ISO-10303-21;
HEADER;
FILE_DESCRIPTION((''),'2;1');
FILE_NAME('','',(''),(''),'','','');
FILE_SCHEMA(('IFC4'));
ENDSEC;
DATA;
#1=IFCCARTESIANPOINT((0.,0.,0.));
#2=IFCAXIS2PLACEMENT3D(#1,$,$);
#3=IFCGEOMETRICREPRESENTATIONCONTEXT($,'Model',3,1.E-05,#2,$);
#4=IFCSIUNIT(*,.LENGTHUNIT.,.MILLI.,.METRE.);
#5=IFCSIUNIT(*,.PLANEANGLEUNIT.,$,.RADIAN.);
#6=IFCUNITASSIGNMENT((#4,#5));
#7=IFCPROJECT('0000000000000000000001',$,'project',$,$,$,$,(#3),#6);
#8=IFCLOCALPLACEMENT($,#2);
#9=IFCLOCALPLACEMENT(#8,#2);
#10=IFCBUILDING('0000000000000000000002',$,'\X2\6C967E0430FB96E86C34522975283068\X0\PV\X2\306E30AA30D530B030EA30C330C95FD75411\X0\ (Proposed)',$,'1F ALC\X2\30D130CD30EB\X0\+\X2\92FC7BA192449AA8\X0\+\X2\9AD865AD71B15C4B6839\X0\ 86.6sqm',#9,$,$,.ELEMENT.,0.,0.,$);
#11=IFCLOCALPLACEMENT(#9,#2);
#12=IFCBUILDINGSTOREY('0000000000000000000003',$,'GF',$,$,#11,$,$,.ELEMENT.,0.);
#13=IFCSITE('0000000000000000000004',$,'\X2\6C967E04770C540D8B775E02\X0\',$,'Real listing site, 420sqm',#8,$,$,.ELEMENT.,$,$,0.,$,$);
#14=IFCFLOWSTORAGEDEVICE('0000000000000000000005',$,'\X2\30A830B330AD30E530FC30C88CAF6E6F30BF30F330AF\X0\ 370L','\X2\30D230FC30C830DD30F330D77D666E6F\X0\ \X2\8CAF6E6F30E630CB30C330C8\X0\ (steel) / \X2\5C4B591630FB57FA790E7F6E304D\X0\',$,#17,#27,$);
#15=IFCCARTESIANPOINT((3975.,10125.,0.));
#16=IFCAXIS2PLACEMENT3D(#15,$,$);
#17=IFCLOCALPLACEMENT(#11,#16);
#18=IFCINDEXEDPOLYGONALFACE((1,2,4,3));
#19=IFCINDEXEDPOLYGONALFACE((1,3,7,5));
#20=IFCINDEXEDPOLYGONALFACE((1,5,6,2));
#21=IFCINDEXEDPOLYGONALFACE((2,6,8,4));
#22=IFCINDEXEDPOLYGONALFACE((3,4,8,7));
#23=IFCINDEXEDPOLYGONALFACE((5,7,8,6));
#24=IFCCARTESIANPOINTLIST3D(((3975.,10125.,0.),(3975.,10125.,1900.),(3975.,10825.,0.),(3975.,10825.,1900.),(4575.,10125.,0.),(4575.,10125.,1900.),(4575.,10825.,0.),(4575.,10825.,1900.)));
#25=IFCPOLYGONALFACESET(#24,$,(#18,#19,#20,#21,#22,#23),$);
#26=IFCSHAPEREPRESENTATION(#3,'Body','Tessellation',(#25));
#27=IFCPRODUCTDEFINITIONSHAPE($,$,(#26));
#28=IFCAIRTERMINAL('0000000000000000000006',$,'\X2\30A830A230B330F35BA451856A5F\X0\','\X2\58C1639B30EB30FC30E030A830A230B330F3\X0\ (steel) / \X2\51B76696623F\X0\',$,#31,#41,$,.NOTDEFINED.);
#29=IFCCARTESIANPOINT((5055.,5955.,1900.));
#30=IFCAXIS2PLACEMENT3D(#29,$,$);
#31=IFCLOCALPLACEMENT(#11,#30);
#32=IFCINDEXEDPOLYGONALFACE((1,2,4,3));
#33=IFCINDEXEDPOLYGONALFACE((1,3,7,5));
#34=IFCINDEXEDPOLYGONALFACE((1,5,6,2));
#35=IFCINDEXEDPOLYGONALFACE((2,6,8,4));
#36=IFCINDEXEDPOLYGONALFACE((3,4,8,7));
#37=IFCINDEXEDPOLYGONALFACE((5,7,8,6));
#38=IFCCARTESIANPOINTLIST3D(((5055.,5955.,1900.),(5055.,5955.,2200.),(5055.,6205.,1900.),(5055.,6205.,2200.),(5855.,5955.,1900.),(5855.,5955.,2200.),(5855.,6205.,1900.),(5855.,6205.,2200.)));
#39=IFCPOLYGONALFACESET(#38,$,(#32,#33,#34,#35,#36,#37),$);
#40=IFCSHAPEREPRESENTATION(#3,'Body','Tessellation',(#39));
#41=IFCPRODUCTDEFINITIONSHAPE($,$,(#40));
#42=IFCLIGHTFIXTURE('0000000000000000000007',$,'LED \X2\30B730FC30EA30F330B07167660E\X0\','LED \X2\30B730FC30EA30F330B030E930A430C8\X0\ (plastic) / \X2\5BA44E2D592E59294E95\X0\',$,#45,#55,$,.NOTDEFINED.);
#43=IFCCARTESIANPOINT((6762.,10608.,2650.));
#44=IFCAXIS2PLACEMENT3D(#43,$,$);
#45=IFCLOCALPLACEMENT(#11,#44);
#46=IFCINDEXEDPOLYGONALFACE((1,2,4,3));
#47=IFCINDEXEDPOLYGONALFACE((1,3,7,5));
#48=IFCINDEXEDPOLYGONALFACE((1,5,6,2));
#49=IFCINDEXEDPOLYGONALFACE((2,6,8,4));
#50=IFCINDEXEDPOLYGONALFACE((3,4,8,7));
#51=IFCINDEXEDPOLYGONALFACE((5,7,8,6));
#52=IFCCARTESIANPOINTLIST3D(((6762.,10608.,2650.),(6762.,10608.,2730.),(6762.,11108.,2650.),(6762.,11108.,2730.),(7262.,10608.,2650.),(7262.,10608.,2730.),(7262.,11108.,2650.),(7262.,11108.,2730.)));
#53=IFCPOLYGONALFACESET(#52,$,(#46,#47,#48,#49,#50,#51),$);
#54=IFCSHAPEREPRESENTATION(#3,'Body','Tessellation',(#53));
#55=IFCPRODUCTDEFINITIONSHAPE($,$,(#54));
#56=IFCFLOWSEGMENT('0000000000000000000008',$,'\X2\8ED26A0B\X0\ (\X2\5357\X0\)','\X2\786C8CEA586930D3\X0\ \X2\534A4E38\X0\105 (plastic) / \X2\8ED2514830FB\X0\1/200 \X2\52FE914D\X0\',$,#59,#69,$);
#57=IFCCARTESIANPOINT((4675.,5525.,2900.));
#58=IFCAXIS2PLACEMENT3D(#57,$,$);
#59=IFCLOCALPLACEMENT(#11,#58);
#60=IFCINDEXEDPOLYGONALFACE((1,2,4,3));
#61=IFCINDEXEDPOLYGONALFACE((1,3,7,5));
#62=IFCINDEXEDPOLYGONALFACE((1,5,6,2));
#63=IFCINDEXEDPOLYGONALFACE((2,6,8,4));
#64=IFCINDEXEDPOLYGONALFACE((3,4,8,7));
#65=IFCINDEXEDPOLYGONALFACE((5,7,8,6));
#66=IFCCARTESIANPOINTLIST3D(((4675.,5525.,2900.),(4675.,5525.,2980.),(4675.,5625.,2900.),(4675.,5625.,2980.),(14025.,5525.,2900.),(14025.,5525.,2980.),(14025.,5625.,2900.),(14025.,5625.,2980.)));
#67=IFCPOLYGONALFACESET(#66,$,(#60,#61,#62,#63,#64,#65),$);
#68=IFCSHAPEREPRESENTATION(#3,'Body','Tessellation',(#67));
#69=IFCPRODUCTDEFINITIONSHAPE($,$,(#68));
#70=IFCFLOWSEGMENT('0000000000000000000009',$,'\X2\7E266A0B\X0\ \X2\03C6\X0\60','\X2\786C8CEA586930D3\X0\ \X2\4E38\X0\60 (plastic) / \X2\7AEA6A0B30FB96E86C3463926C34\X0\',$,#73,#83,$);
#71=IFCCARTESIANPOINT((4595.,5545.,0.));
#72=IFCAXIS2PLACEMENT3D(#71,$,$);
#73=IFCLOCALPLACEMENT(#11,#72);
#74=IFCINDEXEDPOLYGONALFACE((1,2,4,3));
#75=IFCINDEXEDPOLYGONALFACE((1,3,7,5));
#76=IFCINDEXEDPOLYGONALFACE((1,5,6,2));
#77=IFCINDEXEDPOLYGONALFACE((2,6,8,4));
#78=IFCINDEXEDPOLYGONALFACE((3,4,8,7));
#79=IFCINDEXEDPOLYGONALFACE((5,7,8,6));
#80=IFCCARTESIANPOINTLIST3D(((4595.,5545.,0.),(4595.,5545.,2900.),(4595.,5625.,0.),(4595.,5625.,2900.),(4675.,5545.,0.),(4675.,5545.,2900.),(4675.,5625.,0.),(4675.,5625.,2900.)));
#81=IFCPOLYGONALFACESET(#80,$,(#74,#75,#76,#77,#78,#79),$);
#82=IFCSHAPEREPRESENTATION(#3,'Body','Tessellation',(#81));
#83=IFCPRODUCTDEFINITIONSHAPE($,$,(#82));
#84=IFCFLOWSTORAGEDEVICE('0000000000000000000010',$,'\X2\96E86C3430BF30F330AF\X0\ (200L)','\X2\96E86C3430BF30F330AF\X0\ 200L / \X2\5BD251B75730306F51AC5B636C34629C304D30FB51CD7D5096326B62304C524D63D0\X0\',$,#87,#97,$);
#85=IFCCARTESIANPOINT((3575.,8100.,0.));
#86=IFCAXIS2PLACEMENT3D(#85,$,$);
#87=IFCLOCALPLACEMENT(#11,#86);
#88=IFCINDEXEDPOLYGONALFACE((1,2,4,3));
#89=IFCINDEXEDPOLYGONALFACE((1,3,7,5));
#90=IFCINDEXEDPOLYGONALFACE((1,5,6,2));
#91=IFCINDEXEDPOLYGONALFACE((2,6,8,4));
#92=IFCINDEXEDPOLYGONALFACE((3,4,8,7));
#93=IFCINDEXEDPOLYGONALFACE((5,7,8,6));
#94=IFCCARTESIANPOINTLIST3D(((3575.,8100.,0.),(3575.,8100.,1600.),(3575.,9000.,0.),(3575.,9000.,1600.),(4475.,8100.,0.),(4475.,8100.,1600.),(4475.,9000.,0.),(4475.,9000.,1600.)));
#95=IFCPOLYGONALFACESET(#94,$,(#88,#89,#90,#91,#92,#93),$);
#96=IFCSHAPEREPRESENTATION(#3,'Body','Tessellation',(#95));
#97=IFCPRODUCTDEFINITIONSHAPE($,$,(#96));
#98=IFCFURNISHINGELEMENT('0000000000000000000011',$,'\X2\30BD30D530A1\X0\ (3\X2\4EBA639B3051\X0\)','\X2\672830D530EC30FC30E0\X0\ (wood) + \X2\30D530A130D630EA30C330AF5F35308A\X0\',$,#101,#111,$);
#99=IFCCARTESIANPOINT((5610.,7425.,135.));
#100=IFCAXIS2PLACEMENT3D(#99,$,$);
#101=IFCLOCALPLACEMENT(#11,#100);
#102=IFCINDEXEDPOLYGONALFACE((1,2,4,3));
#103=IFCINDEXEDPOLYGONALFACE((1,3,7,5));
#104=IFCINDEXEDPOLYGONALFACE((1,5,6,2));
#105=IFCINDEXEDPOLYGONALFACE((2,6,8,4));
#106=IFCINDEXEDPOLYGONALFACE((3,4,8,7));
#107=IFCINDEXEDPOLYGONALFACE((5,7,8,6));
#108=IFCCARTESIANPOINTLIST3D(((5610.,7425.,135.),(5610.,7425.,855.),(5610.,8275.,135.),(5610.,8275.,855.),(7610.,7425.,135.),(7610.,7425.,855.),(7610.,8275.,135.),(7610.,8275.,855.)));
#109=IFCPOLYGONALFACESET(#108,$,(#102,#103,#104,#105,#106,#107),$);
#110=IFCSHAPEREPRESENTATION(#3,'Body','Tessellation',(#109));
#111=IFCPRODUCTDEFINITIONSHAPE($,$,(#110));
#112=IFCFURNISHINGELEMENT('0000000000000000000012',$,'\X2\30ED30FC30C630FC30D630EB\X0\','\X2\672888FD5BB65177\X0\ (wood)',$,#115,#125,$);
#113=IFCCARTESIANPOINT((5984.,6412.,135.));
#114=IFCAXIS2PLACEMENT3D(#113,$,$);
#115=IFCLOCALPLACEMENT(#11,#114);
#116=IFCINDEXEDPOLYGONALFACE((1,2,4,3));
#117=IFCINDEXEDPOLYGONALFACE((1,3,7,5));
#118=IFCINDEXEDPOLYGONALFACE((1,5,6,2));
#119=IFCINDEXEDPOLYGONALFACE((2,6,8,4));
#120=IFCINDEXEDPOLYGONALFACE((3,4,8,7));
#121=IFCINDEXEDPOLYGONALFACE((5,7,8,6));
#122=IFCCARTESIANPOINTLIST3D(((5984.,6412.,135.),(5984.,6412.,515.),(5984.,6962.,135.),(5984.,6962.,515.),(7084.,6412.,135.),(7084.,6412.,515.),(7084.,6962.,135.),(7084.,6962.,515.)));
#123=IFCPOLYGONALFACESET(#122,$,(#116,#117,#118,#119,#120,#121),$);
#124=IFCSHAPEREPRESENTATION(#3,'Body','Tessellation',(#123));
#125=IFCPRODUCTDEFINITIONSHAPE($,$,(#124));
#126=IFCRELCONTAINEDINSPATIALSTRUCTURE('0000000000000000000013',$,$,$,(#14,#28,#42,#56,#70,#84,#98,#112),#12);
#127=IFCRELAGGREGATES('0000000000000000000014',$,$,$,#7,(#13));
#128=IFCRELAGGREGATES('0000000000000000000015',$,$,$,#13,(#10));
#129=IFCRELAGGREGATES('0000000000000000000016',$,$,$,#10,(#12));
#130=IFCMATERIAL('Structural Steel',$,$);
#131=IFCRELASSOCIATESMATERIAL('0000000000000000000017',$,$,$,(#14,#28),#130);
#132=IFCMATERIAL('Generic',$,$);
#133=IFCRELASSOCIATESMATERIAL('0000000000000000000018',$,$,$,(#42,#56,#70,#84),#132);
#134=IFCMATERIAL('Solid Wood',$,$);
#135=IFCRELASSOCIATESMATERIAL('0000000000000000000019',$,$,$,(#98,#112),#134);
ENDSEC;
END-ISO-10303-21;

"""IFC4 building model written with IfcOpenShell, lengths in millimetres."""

from ifc_helpers import new_model, si_unit, frame, frame_2d, origin, place, context, project, spatial, rectangle, extrude, material, element, save


model = new_model("IFC4")

# Units and contexts
model_context = context("Model", 3, precision=1e-05, world=origin())
ifc_project = project(units=[si_unit("LENGTHUNIT", "METRE", prefix="MILLI"), si_unit("PLANEANGLEUNIT", "RADIAN")], contexts=[model_context])

# Site, building, storey
site_placement = place(None, origin())
site = spatial("IfcSite", under=ifc_project, at=site_placement, Name="沖縄県名護市", ObjectType="Real listing site, 420sqm", CompositionType="ELEMENT", RefElevation=0.0)
building_placement = place(site_placement, origin())
building = spatial("IfcBuilding", under=site, at=building_placement, Name="沖縄・雨水利用とPVのオフグリッド志向 (Proposed)", ObjectType="1F ALCパネル+鋼管鉄骨+高断熱屋根 86.6sqm", CompositionType="ELEMENT", ElevationOfRefHeight=0.0, ElevationOfTerrain=0.0)
storey_placement = place(building_placement, origin())
storey = spatial("IfcBuildingStorey", under=building, at=storey_placement, Name="GF", CompositionType="ELEMENT", Elevation=0.0)

# Shared definitions
ifc_material_1 = material(Name="Solid Wood")

# Shared definitions
ifc_material_2 = material(Name="Structural Steel")

# Shared definitions
ifc_material_3 = material(Name="Generic")

# Flow storage device
flow_storage_device_1_placement = place(storey_placement, frame((3975.0, 10125.0, 0.0)))
element("IfcFlowStorageDevice", 1, at=flow_storage_device_1_placement, inside=storey, material=ifc_material_2, Name="エコキュート貯湯タンク 370L", Description="ヒートポンプ給湯 貯湯ユニット (steel) / 屋外・基礎置き", context=model_context, shape_type="SweptSolid", body=[
    extrude(rectangle(XDim=600.0, YDim=700.0, at=frame_2d((300.0, 350.0))), frame((3975.0, 10125.0, 0.0)), (0.0, 0.0, 1.0), 1900.0),
])

# Air terminal
air_terminal_placement = place(storey_placement, frame((5055.0, 5955.0, 1900.0)))
element("IfcAirTerminal", 2, at=air_terminal_placement, inside=storey, material=ifc_material_2, Name="エアコン室内機", Description="壁掛ルームエアコン (steel) / 冷暖房", PredefinedType="NOTDEFINED", context=model_context, shape_type="SweptSolid", body=[
    extrude(rectangle(XDim=800.0, YDim=250.0, at=frame_2d((400.0, 125.0))), frame((5055.0, 5955.0, 1900.0)), (0.0, 0.0, 1.0), 300.0),
])

# Light fixture
light_fixture_placement = place(storey_placement, frame((6762.0, 10608.0, 2650.0)))
element("IfcLightFixture", 3, at=light_fixture_placement, inside=storey, material=ifc_material_3, Name="LED シーリング照明", Description="LED シーリングライト (plastic) / 室中央天井", PredefinedType="NOTDEFINED", context=model_context, shape_type="SweptSolid", body=[
    extrude(rectangle(XDim=500.0, YDim=500.0, at=frame_2d((250.0, 250.0))), frame((6762.0, 10608.0, 2650.0)), (0.0, 0.0, 1.0), 80.0),
])

# Flow segments
flow_segment_1_placement = place(storey_placement, frame((4675.0, 5525.0, 2900.0)))
element("IfcFlowSegment", 4, at=flow_segment_1_placement, inside=storey, material=ifc_material_3, Name="軒樋 (南)", Description="硬質塩ビ 半丸105 (plastic) / 軒先・1/200 勾配", context=model_context, shape_type="SweptSolid", body=[
    extrude(rectangle(XDim=9350.0, YDim=100.0, at=frame_2d((4675.0, 50.0))), frame((4675.0, 5525.0, 2900.0)), (0.0, 0.0, 1.0), 80.0),
])
flow_segment_2_placement = place(storey_placement, frame((4595.0, 5545.0, 0.0)))
element("IfcFlowSegment", 5, at=flow_segment_2_placement, inside=storey, material=ifc_material_3, Name="縦樋 φ60", Description="硬質塩ビ 丸60 (plastic) / 竪樋・雨水排水", context=model_context, shape_type="SweptSolid", body=[
    extrude(rectangle(XDim=80.0, YDim=80.0, at=frame_2d((40.0, 40.0))), frame((4595.0, 5545.0, 0.0)), (0.0, 0.0, 1.0), 2900.0),
])

# Flow storage device
flow_storage_device_2_placement = place(storey_placement, frame((3575.0, 8100.0, 0.0)))
element("IfcFlowStorageDevice", 6, at=flow_storage_device_2_placement, inside=storey, material=ifc_material_3, Name="雨水タンク (200L)", Description="雨水タンク 200L / 寒冷地は冬季水抜き・凍結防止が前提", context=model_context, shape_type="SweptSolid", body=[
    extrude(rectangle(XDim=900.0, YDim=900.0, at=frame_2d((450.0, 450.0))), frame((3575.0, 8100.0, 0.0)), (0.0, 0.0, 1.0), 1600.0),
])

# Furnishing elements
furnishing_1_placement = place(storey_placement, frame((5610.0, 7425.0, 135.0)))
element("IfcFurnishingElement", 7, at=furnishing_1_placement, inside=storey, material=ifc_material_1, Name="ソファ (3人掛け)", Description="木フレーム (wood) + ファブリック張り", context=model_context, shape_type="SweptSolid", body=[
    extrude(rectangle(XDim=2000.0, YDim=850.0, at=frame_2d((1000.0, 425.0))), frame((5610.0, 7425.0, 135.0)), (0.0, 0.0, 1.0), 720.0),
])
furnishing_2_placement = place(storey_placement, frame((5984.0, 6412.0, 135.0)))
element("IfcFurnishingElement", 8, at=furnishing_2_placement, inside=storey, material=ifc_material_1, Name="ローテーブル", Description="木製家具 (wood)", context=model_context, shape_type="SweptSolid", body=[
    extrude(rectangle(XDim=1100.0, YDim=550.0, at=frame_2d((550.0, 275.0))), frame((5984.0, 6412.0, 135.0)), (0.0, 0.0, 1.0), 380.0),
])

save(model, "model.ifc")
